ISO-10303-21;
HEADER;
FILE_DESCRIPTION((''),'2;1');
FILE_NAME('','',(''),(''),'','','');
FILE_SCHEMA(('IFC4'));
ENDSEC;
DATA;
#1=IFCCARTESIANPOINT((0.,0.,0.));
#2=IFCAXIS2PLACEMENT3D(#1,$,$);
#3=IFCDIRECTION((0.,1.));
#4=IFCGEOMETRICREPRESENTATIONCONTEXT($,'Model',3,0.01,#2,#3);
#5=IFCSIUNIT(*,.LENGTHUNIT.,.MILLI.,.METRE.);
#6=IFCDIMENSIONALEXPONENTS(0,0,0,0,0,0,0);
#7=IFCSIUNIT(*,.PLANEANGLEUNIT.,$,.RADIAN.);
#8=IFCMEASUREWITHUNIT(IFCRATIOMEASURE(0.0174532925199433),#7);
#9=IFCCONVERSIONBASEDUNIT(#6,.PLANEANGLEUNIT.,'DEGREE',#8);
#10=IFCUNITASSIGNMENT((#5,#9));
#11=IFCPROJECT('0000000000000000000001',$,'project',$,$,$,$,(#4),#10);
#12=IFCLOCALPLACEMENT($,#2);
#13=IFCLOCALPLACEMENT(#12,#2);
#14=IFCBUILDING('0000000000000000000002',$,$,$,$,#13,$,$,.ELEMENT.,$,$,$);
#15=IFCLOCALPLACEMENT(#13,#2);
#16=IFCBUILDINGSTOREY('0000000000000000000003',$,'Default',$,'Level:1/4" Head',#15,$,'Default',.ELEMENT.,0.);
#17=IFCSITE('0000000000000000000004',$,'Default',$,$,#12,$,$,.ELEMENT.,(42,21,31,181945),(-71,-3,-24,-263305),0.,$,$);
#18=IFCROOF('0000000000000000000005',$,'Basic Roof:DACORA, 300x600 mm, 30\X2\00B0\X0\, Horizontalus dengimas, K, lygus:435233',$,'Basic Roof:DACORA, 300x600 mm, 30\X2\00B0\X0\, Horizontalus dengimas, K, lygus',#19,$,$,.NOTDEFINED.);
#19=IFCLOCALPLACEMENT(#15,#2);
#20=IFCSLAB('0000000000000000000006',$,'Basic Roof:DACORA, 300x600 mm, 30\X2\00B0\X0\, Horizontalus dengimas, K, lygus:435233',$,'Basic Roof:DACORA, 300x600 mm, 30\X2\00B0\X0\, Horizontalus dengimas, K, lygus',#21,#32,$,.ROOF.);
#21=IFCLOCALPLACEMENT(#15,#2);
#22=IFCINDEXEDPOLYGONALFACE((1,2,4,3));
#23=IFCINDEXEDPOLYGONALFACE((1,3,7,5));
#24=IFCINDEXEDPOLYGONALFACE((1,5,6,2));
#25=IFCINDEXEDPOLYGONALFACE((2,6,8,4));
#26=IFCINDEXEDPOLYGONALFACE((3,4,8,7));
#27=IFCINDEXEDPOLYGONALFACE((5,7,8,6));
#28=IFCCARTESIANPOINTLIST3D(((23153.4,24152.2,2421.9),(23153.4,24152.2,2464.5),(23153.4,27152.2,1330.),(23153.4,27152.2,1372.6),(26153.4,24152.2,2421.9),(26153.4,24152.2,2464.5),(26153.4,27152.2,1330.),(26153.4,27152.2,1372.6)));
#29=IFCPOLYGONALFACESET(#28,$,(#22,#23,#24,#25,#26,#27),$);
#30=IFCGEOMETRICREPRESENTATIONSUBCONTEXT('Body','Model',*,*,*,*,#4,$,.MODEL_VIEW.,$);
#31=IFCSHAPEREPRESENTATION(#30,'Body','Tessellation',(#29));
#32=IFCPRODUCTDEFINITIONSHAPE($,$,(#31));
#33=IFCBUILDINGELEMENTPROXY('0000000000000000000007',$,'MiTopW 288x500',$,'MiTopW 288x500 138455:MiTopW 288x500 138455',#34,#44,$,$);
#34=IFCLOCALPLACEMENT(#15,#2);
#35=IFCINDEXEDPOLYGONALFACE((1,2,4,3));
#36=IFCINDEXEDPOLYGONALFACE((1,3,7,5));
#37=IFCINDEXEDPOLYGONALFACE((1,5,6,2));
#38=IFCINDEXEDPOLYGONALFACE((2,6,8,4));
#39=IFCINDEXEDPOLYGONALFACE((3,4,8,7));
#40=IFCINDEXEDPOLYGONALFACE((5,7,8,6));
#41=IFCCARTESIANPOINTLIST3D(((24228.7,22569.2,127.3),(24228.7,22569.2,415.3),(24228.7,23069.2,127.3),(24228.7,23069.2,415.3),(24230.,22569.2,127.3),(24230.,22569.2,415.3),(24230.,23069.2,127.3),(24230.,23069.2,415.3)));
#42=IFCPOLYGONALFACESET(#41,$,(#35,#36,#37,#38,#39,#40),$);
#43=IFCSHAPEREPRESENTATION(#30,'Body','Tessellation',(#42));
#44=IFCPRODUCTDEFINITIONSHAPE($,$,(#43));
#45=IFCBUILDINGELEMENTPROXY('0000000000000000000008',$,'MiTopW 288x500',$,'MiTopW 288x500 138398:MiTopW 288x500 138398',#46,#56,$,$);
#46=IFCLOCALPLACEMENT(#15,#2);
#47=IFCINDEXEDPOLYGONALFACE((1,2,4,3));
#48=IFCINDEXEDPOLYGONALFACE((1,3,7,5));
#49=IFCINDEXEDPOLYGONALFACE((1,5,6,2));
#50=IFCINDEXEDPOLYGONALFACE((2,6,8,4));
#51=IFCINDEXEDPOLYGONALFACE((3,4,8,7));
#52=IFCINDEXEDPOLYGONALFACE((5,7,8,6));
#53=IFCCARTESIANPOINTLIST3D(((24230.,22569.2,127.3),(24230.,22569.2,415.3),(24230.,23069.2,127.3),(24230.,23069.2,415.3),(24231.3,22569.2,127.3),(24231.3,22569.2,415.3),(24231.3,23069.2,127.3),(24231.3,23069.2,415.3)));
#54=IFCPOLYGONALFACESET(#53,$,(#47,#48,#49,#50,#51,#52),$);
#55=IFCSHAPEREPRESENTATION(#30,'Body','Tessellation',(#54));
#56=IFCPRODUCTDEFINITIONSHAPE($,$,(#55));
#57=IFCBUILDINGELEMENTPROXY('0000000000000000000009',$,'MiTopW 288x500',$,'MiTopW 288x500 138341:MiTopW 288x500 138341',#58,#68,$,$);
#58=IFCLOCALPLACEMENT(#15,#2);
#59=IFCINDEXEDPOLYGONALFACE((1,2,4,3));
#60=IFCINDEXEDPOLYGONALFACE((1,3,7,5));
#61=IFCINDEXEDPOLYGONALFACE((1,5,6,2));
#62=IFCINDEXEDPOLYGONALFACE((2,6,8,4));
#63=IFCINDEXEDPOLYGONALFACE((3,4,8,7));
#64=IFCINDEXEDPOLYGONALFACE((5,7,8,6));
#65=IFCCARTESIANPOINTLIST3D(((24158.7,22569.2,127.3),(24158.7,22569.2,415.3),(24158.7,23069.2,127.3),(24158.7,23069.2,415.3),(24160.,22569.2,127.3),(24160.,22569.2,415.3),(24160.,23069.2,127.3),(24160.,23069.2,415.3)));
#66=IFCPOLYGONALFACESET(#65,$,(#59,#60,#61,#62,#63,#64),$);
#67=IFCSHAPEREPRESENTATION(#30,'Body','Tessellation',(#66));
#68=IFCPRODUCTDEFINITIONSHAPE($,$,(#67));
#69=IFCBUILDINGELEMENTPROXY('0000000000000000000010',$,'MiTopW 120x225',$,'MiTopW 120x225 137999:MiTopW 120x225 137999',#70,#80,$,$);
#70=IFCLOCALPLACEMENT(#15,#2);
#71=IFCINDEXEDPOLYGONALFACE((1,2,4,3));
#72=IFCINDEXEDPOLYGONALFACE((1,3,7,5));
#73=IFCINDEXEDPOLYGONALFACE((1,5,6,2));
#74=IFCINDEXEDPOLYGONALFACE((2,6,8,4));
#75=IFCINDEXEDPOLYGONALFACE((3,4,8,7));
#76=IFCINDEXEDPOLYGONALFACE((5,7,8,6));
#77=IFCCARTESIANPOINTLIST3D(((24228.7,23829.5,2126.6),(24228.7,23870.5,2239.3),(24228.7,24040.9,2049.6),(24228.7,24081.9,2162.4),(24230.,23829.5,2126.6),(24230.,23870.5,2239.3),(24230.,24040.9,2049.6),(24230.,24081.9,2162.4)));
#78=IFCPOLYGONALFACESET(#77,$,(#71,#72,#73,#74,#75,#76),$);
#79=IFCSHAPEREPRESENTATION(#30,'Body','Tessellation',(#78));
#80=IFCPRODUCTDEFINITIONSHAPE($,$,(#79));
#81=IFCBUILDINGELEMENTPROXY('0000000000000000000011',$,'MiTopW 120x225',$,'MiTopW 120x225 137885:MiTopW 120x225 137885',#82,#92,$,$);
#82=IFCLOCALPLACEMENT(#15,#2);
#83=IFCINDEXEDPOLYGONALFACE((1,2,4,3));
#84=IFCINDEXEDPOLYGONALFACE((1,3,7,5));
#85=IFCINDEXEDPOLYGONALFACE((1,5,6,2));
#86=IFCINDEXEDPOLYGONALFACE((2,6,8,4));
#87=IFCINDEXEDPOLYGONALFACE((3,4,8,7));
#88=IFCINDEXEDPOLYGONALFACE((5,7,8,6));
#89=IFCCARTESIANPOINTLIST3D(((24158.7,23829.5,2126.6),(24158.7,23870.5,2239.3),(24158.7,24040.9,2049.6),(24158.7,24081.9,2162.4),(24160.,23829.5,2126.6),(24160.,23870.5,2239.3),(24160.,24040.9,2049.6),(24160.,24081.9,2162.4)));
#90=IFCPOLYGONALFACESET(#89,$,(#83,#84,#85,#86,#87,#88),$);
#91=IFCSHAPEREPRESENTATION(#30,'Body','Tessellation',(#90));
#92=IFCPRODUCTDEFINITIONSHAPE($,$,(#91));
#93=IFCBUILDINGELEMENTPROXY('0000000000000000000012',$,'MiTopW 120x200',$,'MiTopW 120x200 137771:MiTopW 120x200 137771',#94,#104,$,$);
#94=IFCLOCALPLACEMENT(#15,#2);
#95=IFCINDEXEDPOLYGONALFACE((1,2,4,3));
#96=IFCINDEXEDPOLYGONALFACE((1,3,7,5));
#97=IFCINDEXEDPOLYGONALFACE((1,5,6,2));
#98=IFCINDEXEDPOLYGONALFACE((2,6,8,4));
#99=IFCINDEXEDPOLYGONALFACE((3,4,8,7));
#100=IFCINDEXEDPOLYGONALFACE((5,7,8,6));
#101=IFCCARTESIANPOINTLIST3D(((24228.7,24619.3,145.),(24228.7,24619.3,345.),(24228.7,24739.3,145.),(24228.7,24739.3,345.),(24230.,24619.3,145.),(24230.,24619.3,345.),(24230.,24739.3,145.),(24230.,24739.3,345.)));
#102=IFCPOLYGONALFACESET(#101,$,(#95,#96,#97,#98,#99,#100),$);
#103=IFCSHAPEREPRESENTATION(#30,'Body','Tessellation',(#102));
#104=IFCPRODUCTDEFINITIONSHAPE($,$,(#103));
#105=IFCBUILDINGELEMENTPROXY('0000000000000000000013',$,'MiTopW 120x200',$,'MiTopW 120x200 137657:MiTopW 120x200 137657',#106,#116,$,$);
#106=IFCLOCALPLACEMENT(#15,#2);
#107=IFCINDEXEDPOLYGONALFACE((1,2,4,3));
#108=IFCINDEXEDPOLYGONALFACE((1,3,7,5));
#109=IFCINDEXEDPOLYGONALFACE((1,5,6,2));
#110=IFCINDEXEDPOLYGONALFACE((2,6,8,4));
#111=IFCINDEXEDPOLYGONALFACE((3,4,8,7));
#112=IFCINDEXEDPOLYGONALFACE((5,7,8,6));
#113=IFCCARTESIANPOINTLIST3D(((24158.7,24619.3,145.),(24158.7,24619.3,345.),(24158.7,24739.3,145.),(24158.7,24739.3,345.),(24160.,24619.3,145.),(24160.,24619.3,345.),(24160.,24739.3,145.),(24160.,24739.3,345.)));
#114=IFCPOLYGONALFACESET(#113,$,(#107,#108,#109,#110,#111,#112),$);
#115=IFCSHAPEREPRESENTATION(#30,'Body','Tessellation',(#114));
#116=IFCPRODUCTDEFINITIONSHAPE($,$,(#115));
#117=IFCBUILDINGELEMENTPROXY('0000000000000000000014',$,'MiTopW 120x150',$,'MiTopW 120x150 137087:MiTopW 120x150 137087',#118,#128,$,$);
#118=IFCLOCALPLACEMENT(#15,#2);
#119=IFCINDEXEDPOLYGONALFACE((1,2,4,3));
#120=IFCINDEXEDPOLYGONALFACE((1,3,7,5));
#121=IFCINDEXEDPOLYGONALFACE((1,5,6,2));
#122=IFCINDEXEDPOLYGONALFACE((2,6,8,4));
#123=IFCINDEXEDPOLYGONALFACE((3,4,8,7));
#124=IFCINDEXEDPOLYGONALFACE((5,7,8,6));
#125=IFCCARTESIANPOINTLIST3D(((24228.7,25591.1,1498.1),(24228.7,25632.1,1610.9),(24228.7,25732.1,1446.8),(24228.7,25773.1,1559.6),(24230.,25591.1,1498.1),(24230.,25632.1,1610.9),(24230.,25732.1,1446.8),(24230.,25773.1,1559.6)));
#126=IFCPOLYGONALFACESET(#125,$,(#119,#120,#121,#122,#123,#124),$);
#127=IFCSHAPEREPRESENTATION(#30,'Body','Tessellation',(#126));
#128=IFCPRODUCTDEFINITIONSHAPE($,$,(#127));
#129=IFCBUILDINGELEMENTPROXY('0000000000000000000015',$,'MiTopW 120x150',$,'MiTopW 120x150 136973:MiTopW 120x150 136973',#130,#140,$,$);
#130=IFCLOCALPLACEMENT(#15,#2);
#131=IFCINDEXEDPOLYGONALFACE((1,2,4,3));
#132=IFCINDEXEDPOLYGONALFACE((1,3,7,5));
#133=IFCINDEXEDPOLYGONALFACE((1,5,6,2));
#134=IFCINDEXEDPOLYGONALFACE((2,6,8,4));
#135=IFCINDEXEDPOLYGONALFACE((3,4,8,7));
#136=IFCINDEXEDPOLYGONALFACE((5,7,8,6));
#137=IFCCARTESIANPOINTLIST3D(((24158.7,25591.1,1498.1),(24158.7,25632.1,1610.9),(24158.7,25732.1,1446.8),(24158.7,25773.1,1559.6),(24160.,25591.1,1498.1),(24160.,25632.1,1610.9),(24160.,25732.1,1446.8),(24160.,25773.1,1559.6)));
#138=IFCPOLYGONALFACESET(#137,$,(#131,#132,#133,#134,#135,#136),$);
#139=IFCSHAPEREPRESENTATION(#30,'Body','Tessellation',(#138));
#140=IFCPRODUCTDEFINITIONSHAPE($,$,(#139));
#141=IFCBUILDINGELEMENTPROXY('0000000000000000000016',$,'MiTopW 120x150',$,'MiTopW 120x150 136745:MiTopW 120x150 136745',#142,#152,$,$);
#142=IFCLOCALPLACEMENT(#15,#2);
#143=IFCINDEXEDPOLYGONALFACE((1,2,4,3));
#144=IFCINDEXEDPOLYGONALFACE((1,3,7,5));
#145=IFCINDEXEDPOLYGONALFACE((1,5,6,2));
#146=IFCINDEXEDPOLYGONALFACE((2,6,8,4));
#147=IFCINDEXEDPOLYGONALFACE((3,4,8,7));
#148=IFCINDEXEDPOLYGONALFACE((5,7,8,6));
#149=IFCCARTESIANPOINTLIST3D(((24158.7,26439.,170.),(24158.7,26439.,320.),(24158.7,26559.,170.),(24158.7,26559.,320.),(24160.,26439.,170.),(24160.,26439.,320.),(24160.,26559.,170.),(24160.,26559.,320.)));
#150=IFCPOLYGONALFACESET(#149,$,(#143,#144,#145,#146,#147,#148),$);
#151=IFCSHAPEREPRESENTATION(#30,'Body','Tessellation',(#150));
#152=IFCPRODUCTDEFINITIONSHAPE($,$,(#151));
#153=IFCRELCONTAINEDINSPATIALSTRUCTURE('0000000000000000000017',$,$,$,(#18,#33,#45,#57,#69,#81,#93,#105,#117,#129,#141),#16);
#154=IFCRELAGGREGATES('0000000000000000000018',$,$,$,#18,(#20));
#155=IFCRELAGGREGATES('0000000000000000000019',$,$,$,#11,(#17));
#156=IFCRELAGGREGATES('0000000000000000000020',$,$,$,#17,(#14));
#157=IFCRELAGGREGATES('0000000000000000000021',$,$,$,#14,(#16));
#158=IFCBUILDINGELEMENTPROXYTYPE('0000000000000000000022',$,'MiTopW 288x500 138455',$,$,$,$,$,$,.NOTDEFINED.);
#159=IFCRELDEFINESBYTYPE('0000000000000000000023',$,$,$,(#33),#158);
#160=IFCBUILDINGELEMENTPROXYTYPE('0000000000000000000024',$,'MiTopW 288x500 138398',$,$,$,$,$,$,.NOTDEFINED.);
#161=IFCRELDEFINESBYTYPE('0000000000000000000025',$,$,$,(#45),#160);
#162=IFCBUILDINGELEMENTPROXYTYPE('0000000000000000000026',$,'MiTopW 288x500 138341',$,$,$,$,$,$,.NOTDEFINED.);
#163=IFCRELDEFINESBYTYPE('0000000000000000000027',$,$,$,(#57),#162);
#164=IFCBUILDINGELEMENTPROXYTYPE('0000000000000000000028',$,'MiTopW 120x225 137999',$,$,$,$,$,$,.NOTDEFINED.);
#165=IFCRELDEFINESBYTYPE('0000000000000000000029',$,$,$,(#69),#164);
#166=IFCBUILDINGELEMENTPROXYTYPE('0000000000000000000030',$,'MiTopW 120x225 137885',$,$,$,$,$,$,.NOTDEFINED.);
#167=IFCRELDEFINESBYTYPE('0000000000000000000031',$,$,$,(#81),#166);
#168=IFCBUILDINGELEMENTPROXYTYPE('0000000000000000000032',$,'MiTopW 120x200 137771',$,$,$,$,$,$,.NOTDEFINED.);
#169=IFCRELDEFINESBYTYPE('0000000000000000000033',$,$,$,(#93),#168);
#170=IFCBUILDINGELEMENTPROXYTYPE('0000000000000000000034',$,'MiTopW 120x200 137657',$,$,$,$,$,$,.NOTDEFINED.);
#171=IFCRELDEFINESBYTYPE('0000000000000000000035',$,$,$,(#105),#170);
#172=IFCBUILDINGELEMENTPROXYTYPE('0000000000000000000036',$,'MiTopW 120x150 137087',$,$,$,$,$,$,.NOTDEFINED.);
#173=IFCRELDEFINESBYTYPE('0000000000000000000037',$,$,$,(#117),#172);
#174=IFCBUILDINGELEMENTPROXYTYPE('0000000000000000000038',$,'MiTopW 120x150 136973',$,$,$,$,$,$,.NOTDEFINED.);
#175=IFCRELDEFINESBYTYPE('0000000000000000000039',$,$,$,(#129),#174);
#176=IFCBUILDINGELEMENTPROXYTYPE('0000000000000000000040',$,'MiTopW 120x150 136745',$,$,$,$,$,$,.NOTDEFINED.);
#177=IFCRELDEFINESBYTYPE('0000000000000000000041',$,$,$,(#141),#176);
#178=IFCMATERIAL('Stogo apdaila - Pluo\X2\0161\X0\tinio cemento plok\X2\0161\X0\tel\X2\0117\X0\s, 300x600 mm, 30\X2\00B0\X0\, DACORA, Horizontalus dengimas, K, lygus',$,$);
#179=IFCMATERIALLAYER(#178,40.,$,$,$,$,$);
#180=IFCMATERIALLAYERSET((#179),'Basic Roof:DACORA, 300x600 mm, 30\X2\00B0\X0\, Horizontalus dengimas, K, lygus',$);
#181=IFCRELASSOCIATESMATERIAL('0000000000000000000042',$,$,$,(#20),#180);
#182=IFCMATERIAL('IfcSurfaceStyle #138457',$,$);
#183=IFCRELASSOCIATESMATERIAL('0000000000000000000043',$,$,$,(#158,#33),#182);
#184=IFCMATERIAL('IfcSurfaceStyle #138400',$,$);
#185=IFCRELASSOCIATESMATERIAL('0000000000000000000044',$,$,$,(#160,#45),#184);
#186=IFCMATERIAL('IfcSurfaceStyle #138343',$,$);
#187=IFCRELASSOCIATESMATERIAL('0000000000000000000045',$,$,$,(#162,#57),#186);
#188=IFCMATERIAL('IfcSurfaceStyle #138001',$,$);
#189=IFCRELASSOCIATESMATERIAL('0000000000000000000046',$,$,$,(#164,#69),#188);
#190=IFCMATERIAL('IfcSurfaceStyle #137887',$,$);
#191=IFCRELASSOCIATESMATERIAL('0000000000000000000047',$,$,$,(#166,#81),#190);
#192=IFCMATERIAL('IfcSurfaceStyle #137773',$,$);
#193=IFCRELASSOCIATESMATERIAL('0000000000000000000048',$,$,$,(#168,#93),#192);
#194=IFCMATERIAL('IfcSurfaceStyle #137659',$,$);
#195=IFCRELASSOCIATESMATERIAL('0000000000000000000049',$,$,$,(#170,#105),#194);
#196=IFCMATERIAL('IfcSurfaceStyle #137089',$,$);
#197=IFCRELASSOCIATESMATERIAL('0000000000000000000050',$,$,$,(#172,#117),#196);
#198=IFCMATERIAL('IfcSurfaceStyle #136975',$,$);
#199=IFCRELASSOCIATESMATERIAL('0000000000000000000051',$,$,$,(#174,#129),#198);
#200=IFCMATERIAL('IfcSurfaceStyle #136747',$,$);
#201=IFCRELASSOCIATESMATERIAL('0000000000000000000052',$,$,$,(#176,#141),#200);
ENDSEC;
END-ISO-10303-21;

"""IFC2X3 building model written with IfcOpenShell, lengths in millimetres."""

from ifc_helpers import new_model, entity, si_unit, converted_unit, direction, frame, frame_2d, origin, origin_2d_with_axis, place, context, subcontext, project, spatial, polyline, rectangle, outline, extrude, source, transform, mapped, material, layer, layer_set, type_object, type_shapes, element, aggregate, save


model = new_model("IFC2X3")

# Units and contexts
model_context = context("Model", 3, precision=0.01, world=origin(), true_north=direction((0.0, 1.0)))
body_context = subcontext(model_context, "Body", "Model", "MODEL_VIEW")
ifc_project = project(units=[si_unit("LENGTHUNIT", "METRE", prefix="MILLI"), converted_unit("PLANEANGLEUNIT", "DEGREE", entity("IfcRatioMeasure", 0.0174532925199433), si_unit("PLANEANGLEUNIT", "RADIAN"), dimensions=[0, 0, 0, 0, 0, 0, 0])], contexts=[model_context])

# Site, building, storey
site_placement = place(None, origin())
site = spatial("IfcSite", under=ifc_project, at=site_placement, Name="Default", CompositionType="ELEMENT", RefLatitude=(42, 21, 31, 181945), RefLongitude=(-71, -3, -24, -263305), RefElevation=0.0)
building_placement = place(site_placement, origin())
building = spatial("IfcBuilding", under=site, at=building_placement, CompositionType="ELEMENT")
storey_placement = place(building_placement, origin())
storey = spatial("IfcBuildingStorey", under=building, at=storey_placement, Name="Default", ObjectType="Level:1/4\" Head", LongName="Default", CompositionType="ELEMENT", Elevation=0.0)

# Roof, slab
roof_placement = place(storey_placement, frame((23153.4, 24152.2, 1330.0)))
roof = element("IfcRoof", 1, at=roof_placement, inside=storey, Name="Basic Roof:DACORA, 300x600 mm, 30°, Horizontalus dengimas, K, lygus:435233", ObjectType="Basic Roof:DACORA, 300x600 mm, 30°, Horizontalus dengimas, K, lygus", ShapeType="NOTDEFINED")
ifc_material_1 = material(Name="Stogo apdaila - Pluoštinio cemento plokštelės, 300x600 mm, 30°, DACORA, Horizontalus dengimas, K, lygus")
ifc_layer = layer(ifc_material_1, 40.0)
ifc_layer_set = layer_set([ifc_layer], Name="Basic Roof:DACORA, 300x600 mm, 30°, Horizontalus dengimas, K, lygus")
slab_placement = place(roof_placement, origin())
slab = element("IfcSlab", 2, at=slab_placement, material=ifc_layer_set, Name="Basic Roof:DACORA, 300x600 mm, 30°, Horizontalus dengimas, K, lygus:435233", ObjectType="Basic Roof:DACORA, 300x600 mm, 30°, Horizontalus dengimas, K, lygus", PredefinedType="ROOF", context=body_context, shape_type="SweptSolid", body=[
    extrude(rectangle(XDim=3192.5, YDim=3000.0, at=frame_2d((0.0, 0.0), x_axis=(0.0, 1.0))), frame((1500.0, 1500.0, 546.0), z_axis=(0.0, 0.34202, 0.939693), x_axis=(1.0, 0.0, 0.0)), (0.0, -0.34202, 0.939693), 42.6),
])
aggregate(roof, [slab])

# Building element proxies
ifc_material_2 = material(Name="IfcSurfaceStyle #138457")
building_element_proxy_type_1 = type_object("IfcBuildingElementProxyType", Name="MiTopW 288x500 138455", PredefinedType="NOTDEFINED", material=ifc_material_2)
shared_shape_1 = source(origin(), body_context, "Body", "SweptSolid", [
    extrude(rectangle(XDim=500.0, YDim=288.0, at=origin_2d_with_axis()), frame((250.0, 144.0, 0.0), z_axis=(0.0, 0.0, 1.0), x_axis=(-1.0, 0.0, 0.0)), (0.0, 0.0, 1.0), 1.3),
])
type_shapes(building_element_proxy_type_1, [shared_shape_1])
proxy_1_placement = place(building_placement, frame((24230.0, 23069.2, 127.3), z_axis=(-1.0, 0.0, 0.0), x_axis=(0.0, -1.0, 0.0)))
element("IfcBuildingElementProxy", 3, at=proxy_1_placement, inside=storey, type_object=building_element_proxy_type_1, material=ifc_material_2, Name="MiTopW 288x500", ObjectType="MiTopW 288x500 138455:MiTopW 288x500 138455", context=body_context, shape_type="MappedRepresentation", body=[
    mapped(shared_shape_1, transform((0.0, 0.0, 0.0), scale=1.0)),
])
ifc_material_3 = material(Name="IfcSurfaceStyle #138400")
building_element_proxy_type_2 = type_object("IfcBuildingElementProxyType", Name="MiTopW 288x500 138398", PredefinedType="NOTDEFINED", material=ifc_material_3)
shared_shape_2 = source(origin(), body_context, "Body", "SweptSolid", [
    extrude(rectangle(XDim=500.0, YDim=288.0, at=origin_2d_with_axis()), frame((250.0, 144.0, 0.0), z_axis=(0.0, 0.0, 1.0), x_axis=(-1.0, 0.0, 0.0)), (0.0, 0.0, 1.0), 1.3),
])
type_shapes(building_element_proxy_type_2, [shared_shape_2])
proxy_2_placement = place(building_placement, frame((24231.3, 23069.2, 127.3), z_axis=(-1.0, 0.0, 0.0), x_axis=(0.0, -1.0, 0.0)))
element("IfcBuildingElementProxy", 4, at=proxy_2_placement, inside=storey, type_object=building_element_proxy_type_2, material=ifc_material_3, Name="MiTopW 288x500", ObjectType="MiTopW 288x500 138398:MiTopW 288x500 138398", context=body_context, shape_type="MappedRepresentation", body=[
    mapped(shared_shape_2, transform((0.0, 0.0, 0.0), scale=1.0)),
])
ifc_material_4 = material(Name="IfcSurfaceStyle #138343")
building_element_proxy_type_3 = type_object("IfcBuildingElementProxyType", Name="MiTopW 288x500 138341", PredefinedType="NOTDEFINED", material=ifc_material_4)
shared_shape_3 = source(origin(), body_context, "Body", "SweptSolid", [
    extrude(rectangle(XDim=500.0, YDim=288.0, at=origin_2d_with_axis()), frame((250.0, 144.0, 0.0), z_axis=(0.0, 0.0, 1.0), x_axis=(-1.0, 0.0, 0.0)), (0.0, 0.0, 1.0), 1.3),
])
type_shapes(building_element_proxy_type_3, [shared_shape_3])
proxy_3_placement = place(building_placement, frame((24160.0, 23069.2, 127.3), z_axis=(-1.0, 0.0, 0.0), x_axis=(0.0, -1.0, 0.0)))
element("IfcBuildingElementProxy", 5, at=proxy_3_placement, inside=storey, type_object=building_element_proxy_type_3, material=ifc_material_4, Name="MiTopW 288x500", ObjectType="MiTopW 288x500 138341:MiTopW 288x500 138341", context=body_context, shape_type="MappedRepresentation", body=[
    mapped(shared_shape_3, transform((0.0, 0.0, 0.0), scale=1.0)),
])
ifc_material_5 = material(Name="IfcSurfaceStyle #138001")
building_element_proxy_type_4 = type_object("IfcBuildingElementProxyType", Name="MiTopW 120x225 137999", PredefinedType="NOTDEFINED", material=ifc_material_5)
shared_shape_4 = source(origin(), body_context, "Body", "SweptSolid", [
    extrude(outline(polyline([(-112.5, -60.0), (112.5, -60.0), (112.5, 60.0), (-112.5, 60.0), (-112.5, -60.0)])), frame((112.5, 60.0, 0.0), z_axis=(0.0, 0.0, 1.0), x_axis=(-1.0, 0.0, 0.0)), (0.0, 0.0, 1.0), 1.3),
])
type_shapes(building_element_proxy_type_4, [shared_shape_4])
proxy_4_placement = place(building_placement, frame((24230.0, 24040.9, 2049.6), z_axis=(-1.0, 0.0, 0.0), x_axis=(0.0, -0.939693, 0.34202)))
element("IfcBuildingElementProxy", 6, at=proxy_4_placement, inside=storey, type_object=building_element_proxy_type_4, material=ifc_material_5, Name="MiTopW 120x225", ObjectType="MiTopW 120x225 137999:MiTopW 120x225 137999", context=body_context, shape_type="MappedRepresentation", body=[
    mapped(shared_shape_4, transform((0.0, 0.0, 0.0), scale=1.0)),
])
ifc_material_6 = material(Name="IfcSurfaceStyle #137887")
building_element_proxy_type_5 = type_object("IfcBuildingElementProxyType", Name="MiTopW 120x225 137885", PredefinedType="NOTDEFINED", material=ifc_material_6)
shared_shape_5 = source(origin(), body_context, "Body", "SweptSolid", [
    extrude(outline(polyline([(-112.5, -60.0), (112.5, -60.0), (112.5, 60.0), (-112.5, 60.0), (-112.5, -60.0)])), frame((112.5, 60.0, 0.0), z_axis=(0.0, 0.0, 1.0), x_axis=(-1.0, 0.0, 0.0)), (0.0, 0.0, 1.0), 1.3),
])
type_shapes(building_element_proxy_type_5, [shared_shape_5])
proxy_5_placement = place(building_placement, frame((24160.0, 24040.9, 2049.6), z_axis=(-1.0, 0.0, 0.0), x_axis=(0.0, -0.939693, 0.34202)))
element("IfcBuildingElementProxy", 7, at=proxy_5_placement, inside=storey, type_object=building_element_proxy_type_5, material=ifc_material_6, Name="MiTopW 120x225", ObjectType="MiTopW 120x225 137885:MiTopW 120x225 137885", context=body_context, shape_type="MappedRepresentation", body=[
    mapped(shared_shape_5, transform((0.0, 0.0, 0.0), scale=1.0)),
])
ifc_material_7 = material(Name="IfcSurfaceStyle #137773")
building_element_proxy_type_6 = type_object("IfcBuildingElementProxyType", Name="MiTopW 120x200 137771", PredefinedType="NOTDEFINED", material=ifc_material_7)
shared_shape_6 = source(origin(), body_context, "Body", "SweptSolid", [
    extrude(rectangle(XDim=200.0, YDim=120.0, at=origin_2d_with_axis()), frame((100.0, 60.0, 0.0), z_axis=(0.0, 0.0, 1.0), x_axis=(-1.0, 0.0, 0.0)), (0.0, 0.0, 1.0), 1.3),
])
type_shapes(building_element_proxy_type_6, [shared_shape_6])
proxy_6_placement = place(building_placement, frame((24230.0, 24619.3, 145.0), z_axis=(-1.0, 0.0, 0.0), x_axis=(0.0, 0.0, 1.0)))
element("IfcBuildingElementProxy", 8, at=proxy_6_placement, inside=storey, type_object=building_element_proxy_type_6, material=ifc_material_7, Name="MiTopW 120x200", ObjectType="MiTopW 120x200 137771:MiTopW 120x200 137771", context=body_context, shape_type="MappedRepresentation", body=[
    mapped(shared_shape_6, transform((0.0, 0.0, 0.0), scale=1.0)),
])
ifc_material_8 = material(Name="IfcSurfaceStyle #137659")
building_element_proxy_type_7 = type_object("IfcBuildingElementProxyType", Name="MiTopW 120x200 137657", PredefinedType="NOTDEFINED", material=ifc_material_8)
shared_shape_7 = source(origin(), body_context, "Body", "SweptSolid", [
    extrude(rectangle(XDim=200.0, YDim=120.0, at=origin_2d_with_axis()), frame((100.0, 60.0, 0.0), z_axis=(0.0, 0.0, 1.0), x_axis=(-1.0, 0.0, 0.0)), (0.0, 0.0, 1.0), 1.3),
])
type_shapes(building_element_proxy_type_7, [shared_shape_7])
proxy_7_placement = place(building_placement, frame((24160.0, 24619.3, 145.0), z_axis=(-1.0, 0.0, 0.0), x_axis=(0.0, 0.0, 1.0)))
element("IfcBuildingElementProxy", 9, at=proxy_7_placement, inside=storey, type_object=building_element_proxy_type_7, material=ifc_material_8, Name="MiTopW 120x200", ObjectType="MiTopW 120x200 137657:MiTopW 120x200 137657", context=body_context, shape_type="MappedRepresentation", body=[
    mapped(shared_shape_7, transform((0.0, 0.0, 0.0), scale=1.0)),
])
ifc_material_9 = material(Name="IfcSurfaceStyle #137089")
building_element_proxy_type_8 = type_object("IfcBuildingElementProxyType", Name="MiTopW 120x150 137087", PredefinedType="NOTDEFINED", material=ifc_material_9)
shared_shape_8 = source(origin(), body_context, "Body", "SweptSolid", [
    extrude(outline(polyline([(-75.0, -60.0), (75.0, -60.0), (75.0, 60.0), (-75.0, 60.0), (-75.0, -60.0)])), frame((75.0, 60.0, 0.0), z_axis=(0.0, 0.0, 1.0), x_axis=(-1.0, 0.0, 0.0)), (0.0, 0.0, 1.0), 1.3),
])
type_shapes(building_element_proxy_type_8, [shared_shape_8])
proxy_8_placement = place(building_placement, frame((24230.0, 25732.1, 1446.8), z_axis=(-1.0, 0.0, 0.0), x_axis=(0.0, -0.939693, 0.34202)))
element("IfcBuildingElementProxy", 10, at=proxy_8_placement, inside=storey, type_object=building_element_proxy_type_8, material=ifc_material_9, Name="MiTopW 120x150", ObjectType="MiTopW 120x150 137087:MiTopW 120x150 137087", context=body_context, shape_type="MappedRepresentation", body=[
    mapped(shared_shape_8, transform((0.0, 0.0, 0.0), scale=1.0)),
])
ifc_material_10 = material(Name="IfcSurfaceStyle #136975")
building_element_proxy_type_9 = type_object("IfcBuildingElementProxyType", Name="MiTopW 120x150 136973", PredefinedType="NOTDEFINED", material=ifc_material_10)
shared_shape_9 = source(origin(), body_context, "Body", "SweptSolid", [
    extrude(outline(polyline([(-75.0, -60.0), (75.0, -60.0), (75.0, 60.0), (-75.0, 60.0), (-75.0, -60.0)])), frame((75.0, 60.0, 0.0), z_axis=(0.0, 0.0, 1.0), x_axis=(-1.0, 0.0, 0.0)), (0.0, 0.0, 1.0), 1.3),
])
type_shapes(building_element_proxy_type_9, [shared_shape_9])
proxy_9_placement = place(building_placement, frame((24160.0, 25732.1, 1446.8), z_axis=(-1.0, 0.0, 0.0), x_axis=(0.0, -0.939693, 0.34202)))
element("IfcBuildingElementProxy", 11, at=proxy_9_placement, inside=storey, type_object=building_element_proxy_type_9, material=ifc_material_10, Name="MiTopW 120x150", ObjectType="MiTopW 120x150 136973:MiTopW 120x150 136973", context=body_context, shape_type="MappedRepresentation", body=[
    mapped(shared_shape_9, transform((0.0, 0.0, 0.0), scale=1.0)),
])
ifc_material_11 = material(Name="IfcSurfaceStyle #136747")
building_element_proxy_type_10 = type_object("IfcBuildingElementProxyType", Name="MiTopW 120x150 136745", PredefinedType="NOTDEFINED", material=ifc_material_11)
shared_shape_10 = source(origin(), body_context, "Body", "SweptSolid", [
    extrude(rectangle(XDim=150.0, YDim=120.0, at=frame_2d((0.0, 0.0), x_axis=(1.0, 0.0))), frame((75.0, 60.0, 0.0), z_axis=(0.0, 0.0, 1.0), x_axis=(-1.0, 0.0, 0.0)), (0.0, 0.0, 1.0), 1.3),
])
type_shapes(building_element_proxy_type_10, [shared_shape_10])
proxy_10_placement = place(building_placement, frame((24160.0, 26439.0, 170.0), z_axis=(-1.0, 0.0, 0.0), x_axis=(0.0, 0.0, 1.0)))
element("IfcBuildingElementProxy", 12, at=proxy_10_placement, inside=storey, type_object=building_element_proxy_type_10, material=ifc_material_11, Name="MiTopW 120x150", ObjectType="MiTopW 120x150 136745:MiTopW 120x150 136745", context=body_context, shape_type="MappedRepresentation", body=[
    mapped(shared_shape_10, transform((0.0, 0.0, 0.0), scale=1.0)),
])

save(model, "model.ifc")
